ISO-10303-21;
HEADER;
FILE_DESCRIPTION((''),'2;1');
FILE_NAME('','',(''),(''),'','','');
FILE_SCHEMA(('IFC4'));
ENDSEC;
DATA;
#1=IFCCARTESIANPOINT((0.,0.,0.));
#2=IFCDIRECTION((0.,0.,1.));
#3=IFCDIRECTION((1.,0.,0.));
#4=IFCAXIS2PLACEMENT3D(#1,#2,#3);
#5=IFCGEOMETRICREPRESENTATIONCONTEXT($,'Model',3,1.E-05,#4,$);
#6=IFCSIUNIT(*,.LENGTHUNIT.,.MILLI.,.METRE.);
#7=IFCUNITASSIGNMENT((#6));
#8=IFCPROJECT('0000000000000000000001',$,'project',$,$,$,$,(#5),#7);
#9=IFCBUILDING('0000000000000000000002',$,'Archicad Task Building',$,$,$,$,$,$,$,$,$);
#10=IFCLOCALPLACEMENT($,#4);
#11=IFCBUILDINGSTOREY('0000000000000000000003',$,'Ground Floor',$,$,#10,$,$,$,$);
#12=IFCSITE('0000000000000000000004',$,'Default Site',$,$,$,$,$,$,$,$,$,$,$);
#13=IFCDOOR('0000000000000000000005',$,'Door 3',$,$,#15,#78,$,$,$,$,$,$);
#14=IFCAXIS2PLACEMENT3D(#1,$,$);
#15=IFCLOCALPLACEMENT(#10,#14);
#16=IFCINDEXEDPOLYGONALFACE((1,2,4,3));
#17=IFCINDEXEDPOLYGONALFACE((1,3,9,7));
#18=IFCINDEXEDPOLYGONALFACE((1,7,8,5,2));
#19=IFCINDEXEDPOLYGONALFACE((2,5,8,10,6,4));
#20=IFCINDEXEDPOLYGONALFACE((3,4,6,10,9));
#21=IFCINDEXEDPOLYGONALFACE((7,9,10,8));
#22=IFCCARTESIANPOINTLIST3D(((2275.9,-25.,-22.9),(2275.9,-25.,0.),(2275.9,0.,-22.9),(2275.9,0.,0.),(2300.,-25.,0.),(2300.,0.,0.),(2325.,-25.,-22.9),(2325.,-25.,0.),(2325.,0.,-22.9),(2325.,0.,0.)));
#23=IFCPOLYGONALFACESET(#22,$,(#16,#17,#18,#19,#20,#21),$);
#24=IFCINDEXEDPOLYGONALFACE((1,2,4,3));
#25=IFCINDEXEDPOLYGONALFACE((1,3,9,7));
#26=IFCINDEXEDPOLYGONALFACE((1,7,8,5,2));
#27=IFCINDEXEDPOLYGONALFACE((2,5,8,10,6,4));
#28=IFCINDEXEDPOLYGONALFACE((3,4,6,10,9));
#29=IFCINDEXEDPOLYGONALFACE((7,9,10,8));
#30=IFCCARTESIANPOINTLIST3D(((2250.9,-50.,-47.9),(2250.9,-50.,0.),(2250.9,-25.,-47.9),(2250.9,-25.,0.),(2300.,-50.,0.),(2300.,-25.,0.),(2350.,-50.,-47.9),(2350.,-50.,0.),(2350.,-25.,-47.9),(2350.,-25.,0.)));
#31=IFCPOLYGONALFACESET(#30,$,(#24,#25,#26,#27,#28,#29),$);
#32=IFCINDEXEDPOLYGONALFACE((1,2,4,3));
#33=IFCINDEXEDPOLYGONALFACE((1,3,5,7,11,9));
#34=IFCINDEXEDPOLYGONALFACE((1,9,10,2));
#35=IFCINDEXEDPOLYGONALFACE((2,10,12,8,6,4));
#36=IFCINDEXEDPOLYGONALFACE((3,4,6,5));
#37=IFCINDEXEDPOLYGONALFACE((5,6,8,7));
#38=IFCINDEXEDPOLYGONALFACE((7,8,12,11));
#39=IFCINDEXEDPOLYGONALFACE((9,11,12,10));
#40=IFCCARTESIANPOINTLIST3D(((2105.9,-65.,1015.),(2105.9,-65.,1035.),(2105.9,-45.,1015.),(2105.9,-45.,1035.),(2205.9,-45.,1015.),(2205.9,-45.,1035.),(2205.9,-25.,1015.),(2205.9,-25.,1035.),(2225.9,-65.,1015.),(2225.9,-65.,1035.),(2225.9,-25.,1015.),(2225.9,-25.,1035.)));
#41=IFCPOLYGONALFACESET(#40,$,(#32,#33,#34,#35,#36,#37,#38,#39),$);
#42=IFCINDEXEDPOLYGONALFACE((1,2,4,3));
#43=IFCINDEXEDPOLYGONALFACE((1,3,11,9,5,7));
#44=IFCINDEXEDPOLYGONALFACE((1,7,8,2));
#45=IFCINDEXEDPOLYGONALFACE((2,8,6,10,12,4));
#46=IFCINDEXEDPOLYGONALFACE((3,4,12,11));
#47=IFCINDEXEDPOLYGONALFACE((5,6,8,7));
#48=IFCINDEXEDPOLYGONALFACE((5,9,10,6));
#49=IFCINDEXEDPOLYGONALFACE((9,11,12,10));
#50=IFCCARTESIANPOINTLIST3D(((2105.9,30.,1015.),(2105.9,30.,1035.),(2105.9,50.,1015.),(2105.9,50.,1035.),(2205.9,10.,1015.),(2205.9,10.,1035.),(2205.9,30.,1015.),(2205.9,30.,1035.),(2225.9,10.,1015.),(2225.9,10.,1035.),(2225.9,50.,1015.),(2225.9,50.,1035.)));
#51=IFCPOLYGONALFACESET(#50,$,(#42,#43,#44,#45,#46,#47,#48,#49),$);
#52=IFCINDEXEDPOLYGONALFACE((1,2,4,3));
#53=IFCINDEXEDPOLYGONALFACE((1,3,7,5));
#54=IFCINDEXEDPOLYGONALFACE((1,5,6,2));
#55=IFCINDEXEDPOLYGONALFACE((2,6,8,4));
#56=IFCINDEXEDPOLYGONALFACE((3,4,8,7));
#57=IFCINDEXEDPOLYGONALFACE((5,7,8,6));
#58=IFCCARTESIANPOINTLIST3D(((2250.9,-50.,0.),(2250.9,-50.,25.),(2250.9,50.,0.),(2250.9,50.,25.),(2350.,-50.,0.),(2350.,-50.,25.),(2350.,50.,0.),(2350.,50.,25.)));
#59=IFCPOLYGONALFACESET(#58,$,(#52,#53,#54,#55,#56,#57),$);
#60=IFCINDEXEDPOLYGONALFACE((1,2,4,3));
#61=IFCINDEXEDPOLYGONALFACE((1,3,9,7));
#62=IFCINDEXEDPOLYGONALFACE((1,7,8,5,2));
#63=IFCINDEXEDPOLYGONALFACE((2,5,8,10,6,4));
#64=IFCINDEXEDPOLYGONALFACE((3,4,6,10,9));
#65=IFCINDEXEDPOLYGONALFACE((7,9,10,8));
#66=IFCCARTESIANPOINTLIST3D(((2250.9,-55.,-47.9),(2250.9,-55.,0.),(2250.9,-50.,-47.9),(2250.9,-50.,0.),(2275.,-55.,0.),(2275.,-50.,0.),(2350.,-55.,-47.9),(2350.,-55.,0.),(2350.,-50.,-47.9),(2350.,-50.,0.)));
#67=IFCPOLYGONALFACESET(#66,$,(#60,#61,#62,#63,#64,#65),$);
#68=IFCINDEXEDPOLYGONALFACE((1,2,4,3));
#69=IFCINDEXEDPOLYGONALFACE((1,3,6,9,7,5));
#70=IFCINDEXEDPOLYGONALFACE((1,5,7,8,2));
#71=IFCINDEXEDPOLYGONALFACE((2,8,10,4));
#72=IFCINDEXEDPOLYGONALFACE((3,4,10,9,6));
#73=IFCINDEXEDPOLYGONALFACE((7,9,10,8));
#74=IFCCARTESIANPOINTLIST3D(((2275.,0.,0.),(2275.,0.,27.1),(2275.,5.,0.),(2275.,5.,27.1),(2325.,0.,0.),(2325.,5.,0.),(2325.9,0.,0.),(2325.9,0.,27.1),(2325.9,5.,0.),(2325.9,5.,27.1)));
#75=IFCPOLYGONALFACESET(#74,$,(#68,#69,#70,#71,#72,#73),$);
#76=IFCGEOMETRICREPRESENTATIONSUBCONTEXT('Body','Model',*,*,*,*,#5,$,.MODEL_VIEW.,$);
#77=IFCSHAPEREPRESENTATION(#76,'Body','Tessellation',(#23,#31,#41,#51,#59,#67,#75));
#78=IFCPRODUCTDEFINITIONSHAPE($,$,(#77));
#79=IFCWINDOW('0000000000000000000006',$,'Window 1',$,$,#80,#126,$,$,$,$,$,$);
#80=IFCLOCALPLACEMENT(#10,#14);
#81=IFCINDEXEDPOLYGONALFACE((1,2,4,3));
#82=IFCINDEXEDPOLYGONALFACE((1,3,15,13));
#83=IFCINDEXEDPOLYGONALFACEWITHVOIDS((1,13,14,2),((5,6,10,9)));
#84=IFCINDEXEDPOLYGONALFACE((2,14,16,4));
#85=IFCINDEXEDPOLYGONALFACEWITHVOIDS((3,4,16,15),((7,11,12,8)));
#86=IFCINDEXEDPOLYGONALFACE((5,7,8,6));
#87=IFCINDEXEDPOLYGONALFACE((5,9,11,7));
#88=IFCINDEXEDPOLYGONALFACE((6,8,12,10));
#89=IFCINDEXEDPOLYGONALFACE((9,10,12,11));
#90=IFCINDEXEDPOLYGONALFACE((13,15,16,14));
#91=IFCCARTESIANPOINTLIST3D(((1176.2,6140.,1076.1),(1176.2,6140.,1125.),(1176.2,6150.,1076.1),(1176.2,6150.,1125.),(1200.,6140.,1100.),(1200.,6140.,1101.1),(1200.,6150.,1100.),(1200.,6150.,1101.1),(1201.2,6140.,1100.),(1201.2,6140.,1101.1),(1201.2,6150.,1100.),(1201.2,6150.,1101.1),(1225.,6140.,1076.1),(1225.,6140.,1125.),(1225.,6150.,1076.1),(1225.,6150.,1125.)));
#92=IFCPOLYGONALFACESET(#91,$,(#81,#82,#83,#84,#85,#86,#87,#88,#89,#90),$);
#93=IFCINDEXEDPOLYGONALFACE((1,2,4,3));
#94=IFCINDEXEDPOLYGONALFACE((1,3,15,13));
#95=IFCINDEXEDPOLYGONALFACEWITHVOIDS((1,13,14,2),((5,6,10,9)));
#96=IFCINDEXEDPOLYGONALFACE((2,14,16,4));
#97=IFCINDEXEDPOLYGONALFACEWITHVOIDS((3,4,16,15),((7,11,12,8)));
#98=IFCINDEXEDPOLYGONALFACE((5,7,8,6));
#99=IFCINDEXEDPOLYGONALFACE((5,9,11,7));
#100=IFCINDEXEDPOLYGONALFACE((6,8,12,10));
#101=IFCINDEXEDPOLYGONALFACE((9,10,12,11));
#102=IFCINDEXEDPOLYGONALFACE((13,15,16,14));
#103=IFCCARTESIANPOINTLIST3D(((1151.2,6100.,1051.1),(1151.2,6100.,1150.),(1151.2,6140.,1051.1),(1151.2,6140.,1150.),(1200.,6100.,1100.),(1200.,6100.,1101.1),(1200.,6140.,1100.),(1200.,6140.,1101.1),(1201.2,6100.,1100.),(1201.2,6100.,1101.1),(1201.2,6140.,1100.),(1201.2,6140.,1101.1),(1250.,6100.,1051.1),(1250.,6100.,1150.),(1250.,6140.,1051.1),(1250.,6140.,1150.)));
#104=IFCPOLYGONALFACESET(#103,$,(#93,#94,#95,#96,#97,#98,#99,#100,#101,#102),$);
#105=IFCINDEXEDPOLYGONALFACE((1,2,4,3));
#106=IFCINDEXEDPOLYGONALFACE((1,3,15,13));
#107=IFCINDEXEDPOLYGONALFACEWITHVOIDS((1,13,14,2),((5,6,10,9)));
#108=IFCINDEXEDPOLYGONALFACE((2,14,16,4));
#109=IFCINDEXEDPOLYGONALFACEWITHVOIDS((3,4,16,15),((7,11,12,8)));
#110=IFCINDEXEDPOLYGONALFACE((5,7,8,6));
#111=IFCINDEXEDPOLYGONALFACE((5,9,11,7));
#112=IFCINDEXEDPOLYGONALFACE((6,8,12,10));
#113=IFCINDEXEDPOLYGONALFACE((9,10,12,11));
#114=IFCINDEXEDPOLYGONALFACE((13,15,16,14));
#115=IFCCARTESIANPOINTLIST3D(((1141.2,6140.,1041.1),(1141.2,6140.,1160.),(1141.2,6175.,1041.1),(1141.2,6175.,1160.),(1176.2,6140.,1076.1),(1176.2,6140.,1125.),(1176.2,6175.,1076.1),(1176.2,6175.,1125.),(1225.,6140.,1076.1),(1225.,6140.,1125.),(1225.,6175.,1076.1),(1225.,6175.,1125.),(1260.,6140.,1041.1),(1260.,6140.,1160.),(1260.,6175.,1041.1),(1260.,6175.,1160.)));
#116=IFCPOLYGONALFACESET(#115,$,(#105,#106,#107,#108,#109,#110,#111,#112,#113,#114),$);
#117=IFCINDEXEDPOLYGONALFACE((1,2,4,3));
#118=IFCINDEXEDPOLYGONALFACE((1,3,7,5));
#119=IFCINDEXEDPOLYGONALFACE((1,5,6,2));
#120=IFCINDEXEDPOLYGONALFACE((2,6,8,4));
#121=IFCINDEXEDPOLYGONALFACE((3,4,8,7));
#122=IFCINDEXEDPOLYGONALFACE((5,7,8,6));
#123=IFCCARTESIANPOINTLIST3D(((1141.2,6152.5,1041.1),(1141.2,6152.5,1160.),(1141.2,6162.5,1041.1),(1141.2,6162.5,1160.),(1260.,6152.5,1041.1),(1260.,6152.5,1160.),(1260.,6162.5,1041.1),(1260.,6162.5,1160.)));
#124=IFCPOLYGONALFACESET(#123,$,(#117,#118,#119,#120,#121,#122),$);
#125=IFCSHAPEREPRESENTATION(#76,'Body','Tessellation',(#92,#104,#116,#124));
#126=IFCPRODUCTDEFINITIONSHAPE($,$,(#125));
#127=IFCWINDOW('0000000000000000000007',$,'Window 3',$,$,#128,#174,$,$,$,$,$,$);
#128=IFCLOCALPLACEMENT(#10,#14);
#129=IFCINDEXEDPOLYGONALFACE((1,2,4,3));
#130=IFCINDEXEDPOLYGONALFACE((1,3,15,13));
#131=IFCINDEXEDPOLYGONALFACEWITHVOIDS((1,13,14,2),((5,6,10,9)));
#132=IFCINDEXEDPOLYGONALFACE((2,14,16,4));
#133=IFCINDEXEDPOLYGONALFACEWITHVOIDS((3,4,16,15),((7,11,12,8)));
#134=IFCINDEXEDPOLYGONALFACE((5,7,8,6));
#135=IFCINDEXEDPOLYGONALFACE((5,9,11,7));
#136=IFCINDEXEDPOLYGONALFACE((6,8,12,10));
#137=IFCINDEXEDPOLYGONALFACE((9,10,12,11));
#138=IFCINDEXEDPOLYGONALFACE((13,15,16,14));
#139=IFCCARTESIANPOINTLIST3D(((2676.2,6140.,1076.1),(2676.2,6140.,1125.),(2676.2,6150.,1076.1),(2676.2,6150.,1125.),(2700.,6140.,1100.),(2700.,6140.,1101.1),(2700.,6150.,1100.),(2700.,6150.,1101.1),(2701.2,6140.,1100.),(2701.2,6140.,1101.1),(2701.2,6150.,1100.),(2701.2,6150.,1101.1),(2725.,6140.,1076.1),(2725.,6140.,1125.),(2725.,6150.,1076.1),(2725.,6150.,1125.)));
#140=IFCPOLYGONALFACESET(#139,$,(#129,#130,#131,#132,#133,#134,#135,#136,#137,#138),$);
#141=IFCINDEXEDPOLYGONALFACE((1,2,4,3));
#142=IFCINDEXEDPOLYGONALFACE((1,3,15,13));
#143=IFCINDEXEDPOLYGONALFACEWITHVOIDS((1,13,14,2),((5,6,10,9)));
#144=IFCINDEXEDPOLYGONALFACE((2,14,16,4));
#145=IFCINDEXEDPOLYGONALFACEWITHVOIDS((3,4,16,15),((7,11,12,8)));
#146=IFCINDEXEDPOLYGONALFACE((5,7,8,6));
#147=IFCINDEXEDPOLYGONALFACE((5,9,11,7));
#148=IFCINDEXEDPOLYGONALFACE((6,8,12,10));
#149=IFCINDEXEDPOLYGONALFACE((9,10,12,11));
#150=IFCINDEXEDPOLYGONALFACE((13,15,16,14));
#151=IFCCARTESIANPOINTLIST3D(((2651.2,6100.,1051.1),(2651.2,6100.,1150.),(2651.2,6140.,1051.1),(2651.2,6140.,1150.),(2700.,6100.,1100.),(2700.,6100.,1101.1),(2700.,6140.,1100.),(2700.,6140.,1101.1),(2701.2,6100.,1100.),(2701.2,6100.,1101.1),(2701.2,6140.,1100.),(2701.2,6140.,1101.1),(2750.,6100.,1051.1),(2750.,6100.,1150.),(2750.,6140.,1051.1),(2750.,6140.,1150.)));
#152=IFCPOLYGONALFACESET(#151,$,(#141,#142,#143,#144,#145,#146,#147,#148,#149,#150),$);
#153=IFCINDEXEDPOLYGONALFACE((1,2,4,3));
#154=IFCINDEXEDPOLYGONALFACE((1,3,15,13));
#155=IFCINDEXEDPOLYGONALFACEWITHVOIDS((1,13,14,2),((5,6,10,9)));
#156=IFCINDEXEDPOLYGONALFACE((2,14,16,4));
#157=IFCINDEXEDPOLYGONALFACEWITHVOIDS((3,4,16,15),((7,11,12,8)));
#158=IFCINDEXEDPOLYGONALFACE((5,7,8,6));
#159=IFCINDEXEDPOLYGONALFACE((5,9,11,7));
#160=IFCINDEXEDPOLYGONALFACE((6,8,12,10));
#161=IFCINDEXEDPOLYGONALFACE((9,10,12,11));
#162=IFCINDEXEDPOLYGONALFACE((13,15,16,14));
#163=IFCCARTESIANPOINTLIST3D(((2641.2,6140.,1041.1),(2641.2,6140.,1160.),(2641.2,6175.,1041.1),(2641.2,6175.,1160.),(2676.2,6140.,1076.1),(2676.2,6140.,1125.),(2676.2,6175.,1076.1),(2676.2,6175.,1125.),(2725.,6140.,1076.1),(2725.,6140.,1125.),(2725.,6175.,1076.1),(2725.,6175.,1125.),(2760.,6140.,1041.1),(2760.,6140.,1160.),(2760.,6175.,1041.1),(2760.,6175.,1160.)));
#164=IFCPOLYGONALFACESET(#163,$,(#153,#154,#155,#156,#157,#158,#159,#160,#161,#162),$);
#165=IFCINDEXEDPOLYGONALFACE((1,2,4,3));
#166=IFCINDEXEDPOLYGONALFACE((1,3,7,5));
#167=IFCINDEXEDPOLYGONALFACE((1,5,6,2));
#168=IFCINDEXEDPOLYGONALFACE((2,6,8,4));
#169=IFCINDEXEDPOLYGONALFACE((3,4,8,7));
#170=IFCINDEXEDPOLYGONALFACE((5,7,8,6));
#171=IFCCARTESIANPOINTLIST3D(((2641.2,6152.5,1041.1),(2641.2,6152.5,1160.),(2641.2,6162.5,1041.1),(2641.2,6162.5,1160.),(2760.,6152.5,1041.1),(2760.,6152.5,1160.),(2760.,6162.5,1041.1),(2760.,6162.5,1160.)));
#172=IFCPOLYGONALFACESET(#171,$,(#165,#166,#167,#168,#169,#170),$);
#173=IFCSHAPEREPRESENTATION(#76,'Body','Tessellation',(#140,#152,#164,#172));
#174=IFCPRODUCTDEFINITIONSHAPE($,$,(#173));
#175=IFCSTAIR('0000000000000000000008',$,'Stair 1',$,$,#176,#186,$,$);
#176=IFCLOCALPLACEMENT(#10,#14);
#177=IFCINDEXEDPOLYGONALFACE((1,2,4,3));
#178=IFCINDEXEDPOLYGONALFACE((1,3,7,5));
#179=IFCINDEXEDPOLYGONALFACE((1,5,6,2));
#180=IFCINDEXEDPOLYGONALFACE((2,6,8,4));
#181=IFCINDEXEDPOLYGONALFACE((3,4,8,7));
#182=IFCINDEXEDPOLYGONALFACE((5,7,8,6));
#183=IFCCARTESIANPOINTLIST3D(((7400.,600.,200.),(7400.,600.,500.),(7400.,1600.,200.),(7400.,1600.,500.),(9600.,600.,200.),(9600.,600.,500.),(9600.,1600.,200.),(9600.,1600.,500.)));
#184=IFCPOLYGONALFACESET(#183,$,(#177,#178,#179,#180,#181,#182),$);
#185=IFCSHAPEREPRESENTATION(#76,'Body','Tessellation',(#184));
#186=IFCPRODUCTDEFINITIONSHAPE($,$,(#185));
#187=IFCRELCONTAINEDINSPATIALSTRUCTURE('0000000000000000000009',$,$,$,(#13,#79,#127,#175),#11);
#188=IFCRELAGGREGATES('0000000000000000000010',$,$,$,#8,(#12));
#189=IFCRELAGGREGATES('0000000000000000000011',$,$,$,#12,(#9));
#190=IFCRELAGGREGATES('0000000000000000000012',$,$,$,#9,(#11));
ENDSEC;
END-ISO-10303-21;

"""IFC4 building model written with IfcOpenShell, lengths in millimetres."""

from ifc_helpers import new_model, si_unit, frame, origin_with_axes, place, context, subcontext, project, spatial, line, indexed_curve, outline, extrude, element, save


model = new_model("IFC4")

# Units and contexts
model_context = context("Model", 3, precision=1e-05, world=origin_with_axes())
body_context = subcontext(model_context, "Body", "Model", "MODEL_VIEW")
ifc_project = project(units=[si_unit("LENGTHUNIT", "METRE", prefix="MILLI")], contexts=[model_context])

# Site, building, storey
site = spatial("IfcSite", under=ifc_project, Name="Default Site")
building = spatial("IfcBuilding", under=site, Name="Archicad Task Building")
storey_placement = place(None, origin_with_axes())
storey = spatial("IfcBuildingStorey", under=building, at=storey_placement, Name="Ground Floor")

# Door
door_1_placement = place(storey_placement, frame((2300.0, -50.0, 0.0), z_axis=(0.0, 0.0, 1.0), x_axis=(1.0, 0.0, 0.0)))
element("IfcDoor", 1, at=door_1_placement, inside=storey, Name="Door 3", context=body_context, shape_type="SweptSolid", body=[
    extrude(outline(indexed_curve([(0.0, 0.0), (0.0, 2.1), (0.9, 2.1), (0.9, 0.0), (-24.1, 0.0), (-24.1, -22.9), (25.0, -22.9), (25.0, 0.0)], segments=[line(1, 2, 3, 4, 5, 6, 7, 8, 1)])), frame((0.0, 25.0, 0.0), z_axis=(0.0, -1.0, 0.0), x_axis=(1.0, 0.0, 0.0)), (0.0, 0.0, -1.0), 25.0),
    extrude(outline(indexed_curve([(0.0, 0.0), (0.0, 2.1), (0.9, 2.1), (0.9, 0.0), (-49.1, 0.0), (-49.1, -47.9), (50.0, -47.9), (50.0, 0.0)], segments=[line(1, 2, 3, 4, 5, 6, 7, 8, 1)])), frame((0.0, 0.0, 0.0), z_axis=(0.0, -1.0, 0.0), x_axis=(1.0, 0.0, 0.0)), (0.0, 0.0, -1.0), 25.0),
    extrude(outline(indexed_curve([(0.0, 0.0), (-49.1, 0.0), (-49.1, 35.0), (0.0, 35.0)], segments=[line(1, 2, 3, 4, 1)])), frame((25.0, 25.0, 25.0), z_axis=(0.0, 0.0, 1.0), x_axis=(1.0, 0.0, 0.0)), (0.0, 0.0, 1.0), -47.9),
    extrude(outline(indexed_curve([(0.0, 0.0), (0.0, -40.0), (-120.0, -40.0), (-120.0, -20.0), (-20.0, -20.0), (-20.0, 0.0)], segments=[line(1, 2, 3, 4, 5, 6, 1)])), frame((-74.1, 25.0, 1015.0), z_axis=(0.0, 0.0, 1.0), x_axis=(1.0, 0.0, 0.0)), (0.0, 0.0, 1.0), 20.0),
    extrude(outline(indexed_curve([(0.0, 0.0), (0.0, 40.0), (-120.0, 40.0), (-120.0, 20.0), (-20.0, 20.0), (-20.0, 0.0)], segments=[line(1, 2, 3, 4, 5, 6, 1)])), frame((-74.1, 60.0, 1015.0), z_axis=(0.0, 0.0, 1.0), x_axis=(1.0, 0.0, 0.0)), (0.0, 0.0, 1.0), 20.0),
    extrude(outline(indexed_curve([(0.0, 0.0), (-99.1, 0.0), (-99.1, 100.0), (0.0, 100.0)], segments=[line(1, 2, 3, 4, 1)])), frame((50.0, 0.0, 0.0), z_axis=(0.0, 0.0, 1.0), x_axis=(1.0, 0.0, 0.0)), (0.0, 0.0, 1.0), 25.0),
    extrude(outline(indexed_curve([(0.0, 0.0), (0.0, 27.1), (50.9, 27.1), (50.9, 0.0), (-24.1, 0.0), (-24.1, -47.9), (75.0, -47.9), (75.0, 0.0)], segments=[line(1, 2, 3, 4, 5, 6, 7, 8, 1)])), frame((-25.0, -5.0, 0.0), z_axis=(0.0, -1.0, 0.0), x_axis=(1.0, 0.0, 0.0)), (0.0, 0.0, -1.0), 5.0),
    extrude(outline(indexed_curve([(0.0, 0.0), (0.0, 27.1), (50.9, 27.1), (50.9, 0.0), (0.9, 0.0), (0.9, -22.9), (50.0, -22.9), (50.0, 0.0)], segments=[line(1, 2, 3, 4, 5, 6, 7, 8, 1)])), frame((-25.0, 50.0, 0.0), z_axis=(0.0, -1.0, 0.0), x_axis=(1.0, 0.0, 0.0)), (0.0, 0.0, -1.0), 5.0),
])

# Windows
for number, where, z_axis, x_axis, name in (
    (2, (1200.0, 6050.0, 1100.0), (0.0, 0.0, 1.0), (1.0, 0.0, 0.0), "Window 1"),
    (3, (2700.0, 6050.0, 1100.0), (0.0, 0.0, 1.0), (1.0, 0.0, 0.0), "Window 3"),
):
    element("IfcWindow", number, at=place(storey_placement, frame(where, z_axis=z_axis, x_axis=x_axis)), inside=storey, Name=name, context=body_context, shape_type="SweptSolid", body=[
        extrude(outline(indexed_curve([(0.0, 0.0), (1.2, 0.0), (1.2, 1.1), (0.0, 1.1)], segments=[line(1, 2, 3, 4, 1)]), holes=[indexed_curve([(25.0, 25.0), (-23.8, 25.0), (-23.8, -23.9), (25.0, -23.9)], segments=[line(1, 2, 3, 4, 1)])]), frame((0.0, 90.0, 0.0), z_axis=(0.0, -1.0, 0.0), x_axis=(1.0, 0.0, 0.0)), (0.0, 0.0, -1.0), 10.0),
        extrude(outline(indexed_curve([(0.0, 0.0), (1.2, 0.0), (1.2, 1.1), (0.0, 1.1)], segments=[line(1, 2, 3, 4, 1)]), holes=[indexed_curve([(50.0, 50.0), (-48.8, 50.0), (-48.8, -48.9), (50.0, -48.9)], segments=[line(1, 2, 3, 4, 1)])]), frame((0.0, 50.0, 0.0), z_axis=(0.0, -1.0, 0.0), x_axis=(1.0, 0.0, 0.0)), (0.0, 0.0, -1.0), 40.0),
        extrude(outline(indexed_curve([(0.0, 0.0), (-48.8, 0.0), (-48.8, -48.9), (0.0, -48.9)], segments=[line(1, 2, 3, 4, 1)]), holes=[indexed_curve([(35.0, 35.0), (-83.8, 35.0), (-83.8, -83.9), (35.0, -83.9)], segments=[line(1, 2, 3, 4, 1)])]), frame((25.0, 90.0, 25.0), z_axis=(0.0, -1.0, 0.0), x_axis=(1.0, 0.0, 0.0)), (0.0, 0.0, -1.0), 35.0),
        extrude(outline(indexed_curve([(35.0, 35.0), (-83.8, 35.0), (-83.8, -83.9), (35.0, -83.9)], segments=[line(1, 2, 3, 4, 1)])), frame((25.0, 102.5, 25.0), z_axis=(0.0, -1.0, 0.0), x_axis=(1.0, 0.0, 0.0)), (0.0, 0.0, -1.0), 10.0),
    ])

# Stair
stair_placement = place(storey_placement, frame((7400.0, 600.0, 200.0), z_axis=(0.0, 0.0, 1.0), x_axis=(1.0, 0.0, 0.0)))
element("IfcStair", 4, at=stair_placement, inside=storey, Name="Stair 1", context=body_context, shape_type="SweptSolid", body=[
    extrude(outline(indexed_curve([(0.0, 0.0), (2200.0, 0.0), (2200.0, 1000.0), (0.0, 1000.0), (0.0, 0.0)])), None, (0.0, 0.0, 1.0), 300.0),
])

save(model, "model.ifc")
